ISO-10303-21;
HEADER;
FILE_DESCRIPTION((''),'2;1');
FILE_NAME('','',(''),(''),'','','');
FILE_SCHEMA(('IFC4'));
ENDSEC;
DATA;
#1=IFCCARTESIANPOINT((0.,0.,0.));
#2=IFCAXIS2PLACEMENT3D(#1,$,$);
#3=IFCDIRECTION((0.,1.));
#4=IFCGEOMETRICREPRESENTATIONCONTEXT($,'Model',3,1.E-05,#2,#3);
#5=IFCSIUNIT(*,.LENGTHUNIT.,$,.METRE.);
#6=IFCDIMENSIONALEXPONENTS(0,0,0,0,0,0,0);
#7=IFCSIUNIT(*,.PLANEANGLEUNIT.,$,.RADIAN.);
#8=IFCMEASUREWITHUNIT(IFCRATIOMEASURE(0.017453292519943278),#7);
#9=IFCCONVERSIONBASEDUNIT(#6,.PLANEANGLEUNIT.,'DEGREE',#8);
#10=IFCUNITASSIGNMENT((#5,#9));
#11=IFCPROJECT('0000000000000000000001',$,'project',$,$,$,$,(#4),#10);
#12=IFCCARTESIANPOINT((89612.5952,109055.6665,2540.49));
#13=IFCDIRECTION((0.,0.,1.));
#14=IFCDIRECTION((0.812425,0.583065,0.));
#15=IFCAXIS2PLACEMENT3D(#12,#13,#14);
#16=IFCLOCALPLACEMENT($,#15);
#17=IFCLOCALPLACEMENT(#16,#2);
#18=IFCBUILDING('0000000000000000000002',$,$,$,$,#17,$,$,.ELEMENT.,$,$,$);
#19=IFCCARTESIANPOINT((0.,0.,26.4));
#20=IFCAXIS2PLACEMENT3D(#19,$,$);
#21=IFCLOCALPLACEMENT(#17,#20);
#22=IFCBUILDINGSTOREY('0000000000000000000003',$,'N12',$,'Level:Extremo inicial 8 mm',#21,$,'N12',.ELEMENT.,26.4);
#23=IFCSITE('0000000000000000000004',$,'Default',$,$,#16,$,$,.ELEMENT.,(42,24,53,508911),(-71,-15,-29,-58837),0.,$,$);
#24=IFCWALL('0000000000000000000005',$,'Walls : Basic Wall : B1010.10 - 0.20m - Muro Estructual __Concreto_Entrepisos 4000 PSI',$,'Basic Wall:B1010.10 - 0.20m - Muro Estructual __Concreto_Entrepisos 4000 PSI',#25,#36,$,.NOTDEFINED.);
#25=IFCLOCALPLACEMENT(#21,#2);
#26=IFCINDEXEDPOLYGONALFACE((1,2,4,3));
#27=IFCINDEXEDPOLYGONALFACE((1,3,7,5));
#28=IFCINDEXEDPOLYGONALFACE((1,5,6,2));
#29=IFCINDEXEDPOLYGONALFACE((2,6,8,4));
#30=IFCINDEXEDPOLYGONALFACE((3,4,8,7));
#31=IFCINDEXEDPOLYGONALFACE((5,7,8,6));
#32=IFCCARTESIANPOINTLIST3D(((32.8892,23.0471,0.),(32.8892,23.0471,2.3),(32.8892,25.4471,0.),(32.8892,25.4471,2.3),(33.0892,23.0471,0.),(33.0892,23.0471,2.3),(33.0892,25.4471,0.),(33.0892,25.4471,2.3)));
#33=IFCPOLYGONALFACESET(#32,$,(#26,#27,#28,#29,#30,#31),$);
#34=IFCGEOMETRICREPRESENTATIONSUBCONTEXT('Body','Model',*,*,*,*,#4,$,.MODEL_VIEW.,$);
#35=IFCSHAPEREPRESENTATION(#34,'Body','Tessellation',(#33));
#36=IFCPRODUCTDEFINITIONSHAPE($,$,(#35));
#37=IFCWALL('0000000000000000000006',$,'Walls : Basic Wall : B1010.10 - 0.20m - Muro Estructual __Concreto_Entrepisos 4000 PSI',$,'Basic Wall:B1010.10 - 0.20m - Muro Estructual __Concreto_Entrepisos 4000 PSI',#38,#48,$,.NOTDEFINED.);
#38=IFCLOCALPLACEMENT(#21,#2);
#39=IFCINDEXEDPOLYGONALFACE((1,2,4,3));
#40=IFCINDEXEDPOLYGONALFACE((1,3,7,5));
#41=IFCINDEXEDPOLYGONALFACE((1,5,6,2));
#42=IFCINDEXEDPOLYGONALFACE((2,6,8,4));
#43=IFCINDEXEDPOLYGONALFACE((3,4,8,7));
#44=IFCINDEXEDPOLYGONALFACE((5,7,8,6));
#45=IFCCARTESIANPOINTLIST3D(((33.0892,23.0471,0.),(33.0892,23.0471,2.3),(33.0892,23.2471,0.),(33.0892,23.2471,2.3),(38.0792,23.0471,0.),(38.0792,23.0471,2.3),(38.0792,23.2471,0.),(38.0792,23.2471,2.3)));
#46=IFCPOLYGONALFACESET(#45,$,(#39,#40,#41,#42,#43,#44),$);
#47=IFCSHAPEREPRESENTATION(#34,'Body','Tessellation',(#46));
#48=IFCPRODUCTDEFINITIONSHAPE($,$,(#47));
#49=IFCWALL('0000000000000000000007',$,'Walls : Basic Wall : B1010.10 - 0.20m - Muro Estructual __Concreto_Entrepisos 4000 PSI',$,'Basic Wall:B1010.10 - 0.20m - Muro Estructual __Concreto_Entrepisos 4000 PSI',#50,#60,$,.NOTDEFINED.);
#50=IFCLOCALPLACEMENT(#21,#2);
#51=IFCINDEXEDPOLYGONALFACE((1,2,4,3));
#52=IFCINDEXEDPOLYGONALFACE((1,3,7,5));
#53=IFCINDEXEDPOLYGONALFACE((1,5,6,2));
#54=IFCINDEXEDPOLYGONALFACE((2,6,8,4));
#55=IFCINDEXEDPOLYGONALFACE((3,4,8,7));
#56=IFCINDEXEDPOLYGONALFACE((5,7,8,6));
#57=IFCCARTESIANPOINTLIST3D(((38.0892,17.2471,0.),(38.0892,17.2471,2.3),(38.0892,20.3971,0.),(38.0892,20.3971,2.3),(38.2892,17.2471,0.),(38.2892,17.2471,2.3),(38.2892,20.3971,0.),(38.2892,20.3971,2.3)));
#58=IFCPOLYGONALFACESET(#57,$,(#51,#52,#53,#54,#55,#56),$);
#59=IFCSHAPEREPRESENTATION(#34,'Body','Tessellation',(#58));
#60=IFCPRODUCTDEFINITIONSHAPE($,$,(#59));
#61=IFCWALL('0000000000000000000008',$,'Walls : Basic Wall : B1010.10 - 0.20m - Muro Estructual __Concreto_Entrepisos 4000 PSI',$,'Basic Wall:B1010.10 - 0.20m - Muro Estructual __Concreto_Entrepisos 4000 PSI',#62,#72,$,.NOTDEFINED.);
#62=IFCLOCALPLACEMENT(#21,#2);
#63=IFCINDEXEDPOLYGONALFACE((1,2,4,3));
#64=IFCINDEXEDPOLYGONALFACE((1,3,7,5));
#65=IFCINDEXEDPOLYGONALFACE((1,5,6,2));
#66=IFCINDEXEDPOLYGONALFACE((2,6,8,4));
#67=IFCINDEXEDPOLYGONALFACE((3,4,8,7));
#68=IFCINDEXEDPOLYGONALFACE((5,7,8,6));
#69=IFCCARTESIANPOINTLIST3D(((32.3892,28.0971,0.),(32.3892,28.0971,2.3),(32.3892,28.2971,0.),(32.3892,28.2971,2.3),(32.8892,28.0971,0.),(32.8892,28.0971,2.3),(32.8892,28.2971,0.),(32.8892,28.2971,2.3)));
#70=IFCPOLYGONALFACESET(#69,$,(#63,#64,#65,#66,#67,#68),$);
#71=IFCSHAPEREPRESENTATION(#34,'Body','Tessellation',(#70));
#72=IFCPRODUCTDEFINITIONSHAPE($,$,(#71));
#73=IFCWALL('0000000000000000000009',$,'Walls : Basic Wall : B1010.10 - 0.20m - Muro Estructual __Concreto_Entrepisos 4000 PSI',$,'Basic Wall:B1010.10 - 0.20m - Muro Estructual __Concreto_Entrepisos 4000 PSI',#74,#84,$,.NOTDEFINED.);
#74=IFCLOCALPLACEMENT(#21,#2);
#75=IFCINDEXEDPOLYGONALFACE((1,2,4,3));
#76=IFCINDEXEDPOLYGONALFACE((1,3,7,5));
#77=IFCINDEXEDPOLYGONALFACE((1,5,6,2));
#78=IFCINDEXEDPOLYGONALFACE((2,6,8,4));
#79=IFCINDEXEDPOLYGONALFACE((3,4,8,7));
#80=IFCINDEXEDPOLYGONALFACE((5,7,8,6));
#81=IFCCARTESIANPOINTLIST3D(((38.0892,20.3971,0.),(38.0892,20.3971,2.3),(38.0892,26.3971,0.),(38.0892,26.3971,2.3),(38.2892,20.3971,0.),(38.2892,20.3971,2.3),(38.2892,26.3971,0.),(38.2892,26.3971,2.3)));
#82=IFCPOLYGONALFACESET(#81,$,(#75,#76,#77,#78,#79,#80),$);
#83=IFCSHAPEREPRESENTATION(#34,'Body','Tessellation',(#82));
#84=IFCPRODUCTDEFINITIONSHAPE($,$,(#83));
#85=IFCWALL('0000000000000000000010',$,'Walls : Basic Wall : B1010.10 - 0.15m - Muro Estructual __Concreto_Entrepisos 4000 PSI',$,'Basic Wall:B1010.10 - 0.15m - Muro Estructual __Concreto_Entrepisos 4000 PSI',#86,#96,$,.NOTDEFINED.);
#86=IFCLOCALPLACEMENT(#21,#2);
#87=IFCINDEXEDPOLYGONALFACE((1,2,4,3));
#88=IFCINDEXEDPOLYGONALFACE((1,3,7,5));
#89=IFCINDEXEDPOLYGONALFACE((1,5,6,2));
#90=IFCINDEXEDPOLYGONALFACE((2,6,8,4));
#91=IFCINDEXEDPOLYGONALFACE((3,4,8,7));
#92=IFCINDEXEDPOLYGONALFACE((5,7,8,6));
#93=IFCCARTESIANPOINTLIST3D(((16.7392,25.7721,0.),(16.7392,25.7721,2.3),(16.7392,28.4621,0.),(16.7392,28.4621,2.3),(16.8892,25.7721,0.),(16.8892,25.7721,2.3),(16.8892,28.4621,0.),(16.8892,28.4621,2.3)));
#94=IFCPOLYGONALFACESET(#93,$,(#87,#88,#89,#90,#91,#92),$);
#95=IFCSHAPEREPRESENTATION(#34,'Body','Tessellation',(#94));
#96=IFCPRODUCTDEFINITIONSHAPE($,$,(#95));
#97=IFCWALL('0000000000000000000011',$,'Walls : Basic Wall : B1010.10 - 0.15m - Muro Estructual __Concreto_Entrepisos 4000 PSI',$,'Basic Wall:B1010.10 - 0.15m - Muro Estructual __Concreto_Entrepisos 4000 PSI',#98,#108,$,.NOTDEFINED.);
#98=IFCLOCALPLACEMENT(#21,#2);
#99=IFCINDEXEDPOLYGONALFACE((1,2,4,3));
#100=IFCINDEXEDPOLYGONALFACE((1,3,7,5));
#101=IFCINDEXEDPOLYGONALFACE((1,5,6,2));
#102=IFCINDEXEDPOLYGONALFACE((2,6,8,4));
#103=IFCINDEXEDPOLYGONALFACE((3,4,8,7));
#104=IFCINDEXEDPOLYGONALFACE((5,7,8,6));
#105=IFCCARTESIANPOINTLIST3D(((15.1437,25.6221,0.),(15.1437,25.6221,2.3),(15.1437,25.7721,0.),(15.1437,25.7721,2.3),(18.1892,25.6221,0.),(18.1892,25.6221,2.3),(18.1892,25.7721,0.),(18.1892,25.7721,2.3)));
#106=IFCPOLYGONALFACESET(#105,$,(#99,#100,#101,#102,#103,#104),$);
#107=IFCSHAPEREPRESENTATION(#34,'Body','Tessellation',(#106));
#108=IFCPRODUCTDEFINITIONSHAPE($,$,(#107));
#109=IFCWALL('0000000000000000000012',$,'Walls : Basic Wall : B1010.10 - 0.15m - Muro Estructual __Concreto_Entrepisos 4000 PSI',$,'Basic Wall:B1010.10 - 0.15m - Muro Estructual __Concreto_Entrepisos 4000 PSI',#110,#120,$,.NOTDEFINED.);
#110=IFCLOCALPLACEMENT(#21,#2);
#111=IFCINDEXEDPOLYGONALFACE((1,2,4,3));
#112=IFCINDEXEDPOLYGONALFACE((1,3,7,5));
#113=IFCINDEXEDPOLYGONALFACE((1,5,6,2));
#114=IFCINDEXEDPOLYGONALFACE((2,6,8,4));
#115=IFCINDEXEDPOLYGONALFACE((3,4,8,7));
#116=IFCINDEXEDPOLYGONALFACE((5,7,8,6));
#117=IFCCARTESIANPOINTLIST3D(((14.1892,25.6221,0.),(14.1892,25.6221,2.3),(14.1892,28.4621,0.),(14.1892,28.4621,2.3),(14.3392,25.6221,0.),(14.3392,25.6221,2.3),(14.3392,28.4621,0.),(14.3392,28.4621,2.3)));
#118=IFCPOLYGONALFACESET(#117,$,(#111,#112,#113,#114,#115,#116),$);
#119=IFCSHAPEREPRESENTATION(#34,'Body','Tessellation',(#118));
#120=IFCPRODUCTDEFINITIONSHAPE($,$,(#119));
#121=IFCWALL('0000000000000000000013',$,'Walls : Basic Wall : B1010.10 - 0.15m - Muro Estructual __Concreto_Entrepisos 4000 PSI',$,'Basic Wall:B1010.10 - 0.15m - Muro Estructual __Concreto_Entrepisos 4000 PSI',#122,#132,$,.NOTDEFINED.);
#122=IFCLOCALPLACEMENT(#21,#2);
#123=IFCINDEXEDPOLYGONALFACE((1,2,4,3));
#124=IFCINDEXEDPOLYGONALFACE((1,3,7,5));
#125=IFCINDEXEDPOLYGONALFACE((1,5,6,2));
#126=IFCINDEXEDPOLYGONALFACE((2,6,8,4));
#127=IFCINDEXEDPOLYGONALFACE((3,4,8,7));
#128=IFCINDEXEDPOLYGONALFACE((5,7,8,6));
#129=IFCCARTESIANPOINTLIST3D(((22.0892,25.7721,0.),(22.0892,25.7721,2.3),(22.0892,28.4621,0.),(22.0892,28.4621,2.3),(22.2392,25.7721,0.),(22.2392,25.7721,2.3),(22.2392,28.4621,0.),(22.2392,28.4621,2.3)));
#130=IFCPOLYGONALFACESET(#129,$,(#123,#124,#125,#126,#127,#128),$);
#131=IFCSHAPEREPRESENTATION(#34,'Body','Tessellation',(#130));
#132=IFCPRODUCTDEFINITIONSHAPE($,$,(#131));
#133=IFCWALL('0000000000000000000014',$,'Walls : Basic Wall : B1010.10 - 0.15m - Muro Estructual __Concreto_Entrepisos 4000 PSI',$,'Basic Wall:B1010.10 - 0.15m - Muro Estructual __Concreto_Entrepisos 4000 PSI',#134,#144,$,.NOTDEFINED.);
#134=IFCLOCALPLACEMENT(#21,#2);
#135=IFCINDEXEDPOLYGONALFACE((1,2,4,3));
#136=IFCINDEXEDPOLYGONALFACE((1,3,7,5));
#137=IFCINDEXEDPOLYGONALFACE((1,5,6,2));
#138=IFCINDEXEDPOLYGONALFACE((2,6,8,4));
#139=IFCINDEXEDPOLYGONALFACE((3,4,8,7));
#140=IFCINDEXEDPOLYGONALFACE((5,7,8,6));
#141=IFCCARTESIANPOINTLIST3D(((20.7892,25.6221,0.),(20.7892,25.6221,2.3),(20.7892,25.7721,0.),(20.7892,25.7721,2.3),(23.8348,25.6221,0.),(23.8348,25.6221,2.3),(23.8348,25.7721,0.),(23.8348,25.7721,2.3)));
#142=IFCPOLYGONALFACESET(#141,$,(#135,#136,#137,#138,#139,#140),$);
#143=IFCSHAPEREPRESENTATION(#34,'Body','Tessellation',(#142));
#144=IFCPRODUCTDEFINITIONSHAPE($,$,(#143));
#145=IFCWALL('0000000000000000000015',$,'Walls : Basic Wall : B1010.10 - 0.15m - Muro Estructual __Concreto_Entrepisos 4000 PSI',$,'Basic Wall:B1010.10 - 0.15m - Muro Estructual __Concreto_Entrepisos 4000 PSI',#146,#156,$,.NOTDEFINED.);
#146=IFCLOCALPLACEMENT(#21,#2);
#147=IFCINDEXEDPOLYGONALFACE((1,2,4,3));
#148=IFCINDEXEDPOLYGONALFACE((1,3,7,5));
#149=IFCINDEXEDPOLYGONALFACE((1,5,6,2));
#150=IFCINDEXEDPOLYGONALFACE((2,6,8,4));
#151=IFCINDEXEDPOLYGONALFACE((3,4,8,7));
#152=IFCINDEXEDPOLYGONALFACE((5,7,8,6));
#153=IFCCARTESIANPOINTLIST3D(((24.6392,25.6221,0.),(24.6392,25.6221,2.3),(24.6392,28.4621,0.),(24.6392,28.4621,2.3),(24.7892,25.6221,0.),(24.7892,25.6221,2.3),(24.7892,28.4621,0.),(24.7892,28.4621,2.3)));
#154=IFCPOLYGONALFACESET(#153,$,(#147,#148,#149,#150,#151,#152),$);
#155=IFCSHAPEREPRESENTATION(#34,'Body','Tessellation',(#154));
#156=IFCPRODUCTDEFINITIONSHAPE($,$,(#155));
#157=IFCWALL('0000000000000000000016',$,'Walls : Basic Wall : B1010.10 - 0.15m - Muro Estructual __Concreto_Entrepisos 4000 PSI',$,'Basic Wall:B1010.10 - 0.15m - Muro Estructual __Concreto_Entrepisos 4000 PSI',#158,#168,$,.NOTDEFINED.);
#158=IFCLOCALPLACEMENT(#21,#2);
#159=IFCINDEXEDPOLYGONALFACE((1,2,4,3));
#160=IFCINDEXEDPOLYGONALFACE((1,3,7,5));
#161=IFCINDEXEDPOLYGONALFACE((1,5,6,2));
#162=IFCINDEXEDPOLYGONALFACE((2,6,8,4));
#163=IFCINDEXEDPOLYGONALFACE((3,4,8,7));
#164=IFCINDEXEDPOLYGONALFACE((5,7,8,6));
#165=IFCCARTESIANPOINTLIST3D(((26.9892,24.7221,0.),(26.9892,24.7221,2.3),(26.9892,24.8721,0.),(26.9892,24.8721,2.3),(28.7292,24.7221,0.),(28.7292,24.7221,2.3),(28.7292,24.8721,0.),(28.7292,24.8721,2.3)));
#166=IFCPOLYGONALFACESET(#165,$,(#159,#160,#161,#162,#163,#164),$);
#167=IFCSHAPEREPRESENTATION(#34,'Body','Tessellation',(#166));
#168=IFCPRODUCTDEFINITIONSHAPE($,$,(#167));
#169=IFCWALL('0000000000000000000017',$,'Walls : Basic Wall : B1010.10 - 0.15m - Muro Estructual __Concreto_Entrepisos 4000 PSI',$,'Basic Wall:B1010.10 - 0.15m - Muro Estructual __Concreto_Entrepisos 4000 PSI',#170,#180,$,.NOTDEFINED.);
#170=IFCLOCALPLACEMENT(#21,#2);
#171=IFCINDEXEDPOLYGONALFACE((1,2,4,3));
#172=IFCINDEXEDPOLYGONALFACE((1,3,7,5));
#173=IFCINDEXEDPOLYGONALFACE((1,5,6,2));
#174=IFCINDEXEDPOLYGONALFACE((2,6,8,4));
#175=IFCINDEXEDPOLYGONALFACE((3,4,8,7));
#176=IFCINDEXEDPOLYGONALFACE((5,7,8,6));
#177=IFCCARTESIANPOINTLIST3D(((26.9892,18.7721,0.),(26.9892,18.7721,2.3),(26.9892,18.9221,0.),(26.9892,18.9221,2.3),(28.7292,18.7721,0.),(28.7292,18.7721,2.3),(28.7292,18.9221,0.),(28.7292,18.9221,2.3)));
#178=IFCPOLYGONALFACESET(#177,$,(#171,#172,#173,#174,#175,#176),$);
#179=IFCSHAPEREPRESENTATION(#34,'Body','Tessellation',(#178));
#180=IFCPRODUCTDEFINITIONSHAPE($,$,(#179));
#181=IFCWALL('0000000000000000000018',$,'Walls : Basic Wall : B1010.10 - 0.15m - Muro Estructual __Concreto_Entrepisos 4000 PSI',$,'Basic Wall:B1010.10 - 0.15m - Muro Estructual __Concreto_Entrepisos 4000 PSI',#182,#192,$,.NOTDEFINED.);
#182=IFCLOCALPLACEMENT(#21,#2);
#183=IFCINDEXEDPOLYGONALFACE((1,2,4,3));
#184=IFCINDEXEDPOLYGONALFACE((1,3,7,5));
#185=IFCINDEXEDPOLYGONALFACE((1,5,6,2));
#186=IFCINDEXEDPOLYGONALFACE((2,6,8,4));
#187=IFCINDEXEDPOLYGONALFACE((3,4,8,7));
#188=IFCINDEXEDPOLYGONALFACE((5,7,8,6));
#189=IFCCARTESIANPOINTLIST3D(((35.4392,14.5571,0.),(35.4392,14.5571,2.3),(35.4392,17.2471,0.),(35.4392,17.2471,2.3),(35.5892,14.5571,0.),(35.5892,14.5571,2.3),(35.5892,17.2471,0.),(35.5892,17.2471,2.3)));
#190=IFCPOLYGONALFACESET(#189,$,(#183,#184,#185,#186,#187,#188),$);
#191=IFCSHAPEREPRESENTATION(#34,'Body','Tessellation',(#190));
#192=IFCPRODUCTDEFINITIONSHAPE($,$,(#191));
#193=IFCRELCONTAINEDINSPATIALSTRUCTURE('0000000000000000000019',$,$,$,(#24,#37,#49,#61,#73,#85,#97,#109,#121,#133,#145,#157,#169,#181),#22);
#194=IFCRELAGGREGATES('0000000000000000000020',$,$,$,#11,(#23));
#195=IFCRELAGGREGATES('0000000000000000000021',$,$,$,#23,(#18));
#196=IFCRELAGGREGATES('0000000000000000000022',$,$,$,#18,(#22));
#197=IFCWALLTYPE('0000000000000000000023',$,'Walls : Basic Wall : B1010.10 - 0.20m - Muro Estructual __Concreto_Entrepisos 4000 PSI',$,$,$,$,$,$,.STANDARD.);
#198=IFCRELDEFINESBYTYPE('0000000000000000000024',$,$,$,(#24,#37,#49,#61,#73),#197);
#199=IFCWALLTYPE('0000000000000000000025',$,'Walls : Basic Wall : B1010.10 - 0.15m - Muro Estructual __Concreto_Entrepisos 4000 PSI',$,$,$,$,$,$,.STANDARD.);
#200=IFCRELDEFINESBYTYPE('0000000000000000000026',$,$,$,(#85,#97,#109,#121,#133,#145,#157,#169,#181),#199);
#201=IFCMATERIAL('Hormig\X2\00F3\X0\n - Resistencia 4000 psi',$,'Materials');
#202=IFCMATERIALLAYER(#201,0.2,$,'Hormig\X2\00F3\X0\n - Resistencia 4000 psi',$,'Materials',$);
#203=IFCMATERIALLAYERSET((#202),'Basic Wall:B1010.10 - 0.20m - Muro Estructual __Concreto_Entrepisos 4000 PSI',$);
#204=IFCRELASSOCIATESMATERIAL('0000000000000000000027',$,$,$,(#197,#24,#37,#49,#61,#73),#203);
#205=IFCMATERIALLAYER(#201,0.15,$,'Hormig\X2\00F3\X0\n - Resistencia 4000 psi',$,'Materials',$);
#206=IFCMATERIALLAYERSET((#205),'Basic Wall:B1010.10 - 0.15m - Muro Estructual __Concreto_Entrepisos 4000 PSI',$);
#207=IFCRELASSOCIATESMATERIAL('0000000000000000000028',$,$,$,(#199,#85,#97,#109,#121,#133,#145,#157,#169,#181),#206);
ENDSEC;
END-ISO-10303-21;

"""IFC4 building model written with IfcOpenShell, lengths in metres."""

from ifc_helpers import new_model, entity, si_unit, converted_unit, direction, frame, frame_2d, origin, place, context, subcontext, project, spatial, rectangle, extrude, material, layer, layer_set, layer_usage, type_object, element, save


model = new_model("IFC4")

# Units and contexts
model_context = context("Model", 3, precision=1e-05, world=origin(), true_north=direction((0.0, 1.0)))
body_context = subcontext(model_context, "Body", "Model", "MODEL_VIEW")
ifc_project = project(units=[si_unit("LENGTHUNIT", "METRE"), converted_unit("PLANEANGLEUNIT", "DEGREE", entity("IfcRatioMeasure", 0.017453292519943278), si_unit("PLANEANGLEUNIT", "RADIAN"), dimensions=[0, 0, 0, 0, 0, 0, 0])], contexts=[model_context])

# Site, building, storey
site_placement = place(None, frame((89612.5952, 109055.6665, 2540.49), z_axis=(0.0, 0.0, 1.0), x_axis=(0.812425, 0.583065, 0.0)))
site = spatial("IfcSite", under=ifc_project, at=site_placement, Name="Default", CompositionType="ELEMENT", RefLatitude=(42, 24, 53, 508911), RefLongitude=(-71, -15, -29, -58837), RefElevation=0.0)
building_placement = place(site_placement, origin())
building = spatial("IfcBuilding", under=site, at=building_placement, CompositionType="ELEMENT")
storey_placement = place(building_placement, frame((0.0, 0.0, 26.4)))
storey = spatial("IfcBuildingStorey", under=building, at=storey_placement, Name="N12", ObjectType="Level:Extremo inicial 8 mm", LongName="N12", CompositionType="ELEMENT", Elevation=26.4)

# Walls
ifc_material = material(Name="Hormigón - Resistencia 4000 psi", Category="Materials")
ifc_layer_1 = layer(ifc_material, 0.2, Name="Hormigón - Resistencia 4000 psi", Category="Materials")
ifc_layer_set_1 = layer_set([ifc_layer_1], Name="Basic Wall:B1010.10 - 0.20m - Muro Estructual __Concreto_Entrepisos 4000 PSI")
wall_type_1 = type_object("IfcWallType", Name="Walls : Basic Wall : B1010.10 - 0.20m - Muro Estructual __Concreto_Entrepisos 4000 PSI", PredefinedType="STANDARD", material=ifc_layer_set_1)
ifc_layer_usage_1 = layer_usage(ifc_layer_set_1, "AXIS2", "POSITIVE", -0.1)
wall_1_placement = place(storey_placement, frame((32.9892, 25.4471, 0.0), z_axis=(0.0, 0.0, 1.0), x_axis=(0.0, -1.0, 0.0)))
element("IfcWall", 1, at=wall_1_placement, inside=storey, type_object=wall_type_1, material=ifc_layer_usage_1, Name="Walls : Basic Wall : B1010.10 - 0.20m - Muro Estructual __Concreto_Entrepisos 4000 PSI", ObjectType="Basic Wall:B1010.10 - 0.20m - Muro Estructual __Concreto_Entrepisos 4000 PSI", PredefinedType="NOTDEFINED", context=body_context, shape_type="SweptSolid", body=[
    extrude(rectangle(XDim=2.4, YDim=0.2, at=frame_2d((1.2, 0.0), x_axis=(-1.0, 0.0))), origin(), (0.0, 0.0, 1.0), 2.3),
])
ifc_layer_usage_2 = layer_usage(ifc_layer_set_1, "AXIS2", "POSITIVE", -0.1)
wall_2_placement = place(storey_placement, frame((33.0892, 23.1471, 0.0)))
element("IfcWall", 2, at=wall_2_placement, inside=storey, type_object=wall_type_1, material=ifc_layer_usage_2, Name="Walls : Basic Wall : B1010.10 - 0.20m - Muro Estructual __Concreto_Entrepisos 4000 PSI", ObjectType="Basic Wall:B1010.10 - 0.20m - Muro Estructual __Concreto_Entrepisos 4000 PSI", PredefinedType="NOTDEFINED", context=body_context, shape_type="SweptSolid", body=[
    extrude(rectangle(XDim=4.99, YDim=0.2, at=frame_2d((2.495, 0.0), x_axis=(-1.0, 0.0))), origin(), (0.0, 0.0, 1.0), 2.3),
])
ifc_layer_usage_3 = layer_usage(ifc_layer_set_1, "AXIS2", "POSITIVE", -0.1)
wall_3_placement = place(storey_placement, frame((38.1892, 17.2471, 0.0), z_axis=(0.0, 0.0, 1.0), x_axis=(0.0, 1.0, 0.0)))
element("IfcWall", 3, at=wall_3_placement, inside=storey, type_object=wall_type_1, material=ifc_layer_usage_3, Name="Walls : Basic Wall : B1010.10 - 0.20m - Muro Estructual __Concreto_Entrepisos 4000 PSI", ObjectType="Basic Wall:B1010.10 - 0.20m - Muro Estructual __Concreto_Entrepisos 4000 PSI", PredefinedType="NOTDEFINED", context=body_context, shape_type="SweptSolid", body=[
    extrude(rectangle(XDim=3.15, YDim=0.2, at=frame_2d((1.575, 0.0), x_axis=(-1.0, 0.0))), origin(), (0.0, 0.0, 1.0), 2.3),
])
ifc_layer_usage_4 = layer_usage(ifc_layer_set_1, "AXIS2", "POSITIVE", -0.1)
wall_4_placement = place(storey_placement, frame((32.3892, 28.1971, 0.0)))
element("IfcWall", 4, at=wall_4_placement, inside=storey, type_object=wall_type_1, material=ifc_layer_usage_4, Name="Walls : Basic Wall : B1010.10 - 0.20m - Muro Estructual __Concreto_Entrepisos 4000 PSI", ObjectType="Basic Wall:B1010.10 - 0.20m - Muro Estructual __Concreto_Entrepisos 4000 PSI", PredefinedType="NOTDEFINED", context=body_context, shape_type="SweptSolid", body=[
    extrude(rectangle(XDim=0.5, YDim=0.2, at=frame_2d((0.25, 0.0), x_axis=(-1.0, 0.0))), origin(), (0.0, 0.0, 1.0), 2.3),
])
ifc_layer_usage_5 = layer_usage(ifc_layer_set_1, "AXIS2", "POSITIVE", -0.1)
wall_5_placement = place(storey_placement, frame((38.1892, 20.3971, 0.0), z_axis=(0.0, 0.0, 1.0), x_axis=(0.0, 1.0, 0.0)))
element("IfcWall", 5, at=wall_5_placement, inside=storey, type_object=wall_type_1, material=ifc_layer_usage_5, Name="Walls : Basic Wall : B1010.10 - 0.20m - Muro Estructual __Concreto_Entrepisos 4000 PSI", ObjectType="Basic Wall:B1010.10 - 0.20m - Muro Estructual __Concreto_Entrepisos 4000 PSI", PredefinedType="NOTDEFINED", context=body_context, shape_type="SweptSolid", body=[
    extrude(rectangle(XDim=6.0, YDim=0.2, at=frame_2d((3.0, 0.0), x_axis=(-1.0, 0.0))), origin(), (0.0, 0.0, 1.0), 2.3),
])
ifc_layer_2 = layer(ifc_material, 0.15, Name="Hormigón - Resistencia 4000 psi", Category="Materials")
ifc_layer_set_2 = layer_set([ifc_layer_2], Name="Basic Wall:B1010.10 - 0.15m - Muro Estructual __Concreto_Entrepisos 4000 PSI")
ifc_layer_usage_6 = layer_usage(ifc_layer_set_2, "AXIS2", "POSITIVE", -0.075)
wall_type_2 = type_object("IfcWallType", Name="Walls : Basic Wall : B1010.10 - 0.15m - Muro Estructual __Concreto_Entrepisos 4000 PSI", PredefinedType="STANDARD", material=ifc_layer_set_2)
wall_6_placement = place(storey_placement, frame((16.8142, 28.4621, 0.0), z_axis=(0.0, 0.0, 1.0), x_axis=(0.0, -1.0, 0.0)))
element("IfcWall", 6, at=wall_6_placement, inside=storey, type_object=wall_type_2, material=ifc_layer_usage_6, Name="Walls : Basic Wall : B1010.10 - 0.15m - Muro Estructual __Concreto_Entrepisos 4000 PSI", ObjectType="Basic Wall:B1010.10 - 0.15m - Muro Estructual __Concreto_Entrepisos 4000 PSI", PredefinedType="NOTDEFINED", context=body_context, shape_type="SweptSolid", body=[
    extrude(rectangle(XDim=2.69, YDim=0.15, at=frame_2d((1.345, 0.0), x_axis=(-1.0, 0.0))), origin(), (0.0, 0.0, 1.0), 2.3),
])
ifc_layer_usage_7 = layer_usage(ifc_layer_set_2, "AXIS2", "POSITIVE", -0.075)
wall_7_placement = place(storey_placement, frame((18.1892, 25.6971, 0.0), z_axis=(0.0, 0.0, 1.0), x_axis=(-1.0, 0.0, 0.0)))
element("IfcWall", 7, at=wall_7_placement, inside=storey, type_object=wall_type_2, material=ifc_layer_usage_7, Name="Walls : Basic Wall : B1010.10 - 0.15m - Muro Estructual __Concreto_Entrepisos 4000 PSI", ObjectType="Basic Wall:B1010.10 - 0.15m - Muro Estructual __Concreto_Entrepisos 4000 PSI", PredefinedType="NOTDEFINED", context=body_context, shape_type="SweptSolid", body=[
    extrude(rectangle(XDim=3.0455, YDim=0.15, at=frame_2d((1.5228, 0.0), x_axis=(-1.0, 0.0))), origin(), (0.0, 0.0, 1.0), 2.3),
])
ifc_layer_usage_8 = layer_usage(ifc_layer_set_2, "AXIS2", "POSITIVE", -0.075)
wall_8_placement = place(storey_placement, frame((14.2642, 28.4621, 0.0), z_axis=(0.0, 0.0, 1.0), x_axis=(0.0, -1.0, 0.0)))
element("IfcWall", 8, at=wall_8_placement, inside=storey, type_object=wall_type_2, material=ifc_layer_usage_8, Name="Walls : Basic Wall : B1010.10 - 0.15m - Muro Estructual __Concreto_Entrepisos 4000 PSI", ObjectType="Basic Wall:B1010.10 - 0.15m - Muro Estructual __Concreto_Entrepisos 4000 PSI", PredefinedType="NOTDEFINED", context=body_context, shape_type="SweptSolid", body=[
    extrude(rectangle(XDim=2.84, YDim=0.15, at=frame_2d((1.42, 0.0), x_axis=(-1.0, 0.0))), origin(), (0.0, 0.0, 1.0), 2.3),
])
ifc_layer_usage_9 = layer_usage(ifc_layer_set_2, "AXIS2", "NEGATIVE", 0.075)
wall_9_placement = place(storey_placement, frame((22.1642, 28.4621, 0.0), z_axis=(0.0, 0.0, 1.0), x_axis=(0.0, -1.0, 0.0)))
element("IfcWall", 9, at=wall_9_placement, inside=storey, type_object=wall_type_2, material=ifc_layer_usage_9, Name="Walls : Basic Wall : B1010.10 - 0.15m - Muro Estructual __Concreto_Entrepisos 4000 PSI", ObjectType="Basic Wall:B1010.10 - 0.15m - Muro Estructual __Concreto_Entrepisos 4000 PSI", PredefinedType="NOTDEFINED", context=body_context, shape_type="SweptSolid", body=[
    extrude(rectangle(XDim=2.69, YDim=0.15, at=frame_2d((1.345, 0.0), x_axis=(-1.0, 0.0))), origin(), (0.0, 0.0, 1.0), 2.3),
])
ifc_layer_usage_10 = layer_usage(ifc_layer_set_2, "AXIS2", "NEGATIVE", 0.075)
wall_10_placement = place(storey_placement, frame((20.7892, 25.6971, 0.0)))
element("IfcWall", 10, at=wall_10_placement, inside=storey, type_object=wall_type_2, material=ifc_layer_usage_10, Name="Walls : Basic Wall : B1010.10 - 0.15m - Muro Estructual __Concreto_Entrepisos 4000 PSI", ObjectType="Basic Wall:B1010.10 - 0.15m - Muro Estructual __Concreto_Entrepisos 4000 PSI", PredefinedType="NOTDEFINED", context=body_context, shape_type="SweptSolid", body=[
    extrude(rectangle(XDim=3.0455, YDim=0.15, at=frame_2d((1.5228, 0.0), x_axis=(-1.0, 0.0))), origin(), (0.0, 0.0, 1.0), 2.3),
])
ifc_layer_usage_11 = layer_usage(ifc_layer_set_2, "AXIS2", "NEGATIVE", 0.075)
wall_11_placement = place(storey_placement, frame((24.7142, 28.4621, 0.0), z_axis=(0.0, 0.0, 1.0), x_axis=(0.0, -1.0, 0.0)))
element("IfcWall", 11, at=wall_11_placement, inside=storey, type_object=wall_type_2, material=ifc_layer_usage_11, Name="Walls : Basic Wall : B1010.10 - 0.15m - Muro Estructual __Concreto_Entrepisos 4000 PSI", ObjectType="Basic Wall:B1010.10 - 0.15m - Muro Estructual __Concreto_Entrepisos 4000 PSI", PredefinedType="NOTDEFINED", context=body_context, shape_type="SweptSolid", body=[
    extrude(rectangle(XDim=2.84, YDim=0.15, at=frame_2d((1.42, 0.0), x_axis=(-1.0, 0.0))), origin(), (0.0, 0.0, 1.0), 2.3),
])
ifc_layer_usage_12 = layer_usage(ifc_layer_set_2, "AXIS2", "NEGATIVE", 0.075)
wall_12_placement = place(storey_placement, frame((26.9892, 24.7971, 0.0)))
element("IfcWall", 12, at=wall_12_placement, inside=storey, type_object=wall_type_2, material=ifc_layer_usage_12, Name="Walls : Basic Wall : B1010.10 - 0.15m - Muro Estructual __Concreto_Entrepisos 4000 PSI", ObjectType="Basic Wall:B1010.10 - 0.15m - Muro Estructual __Concreto_Entrepisos 4000 PSI", PredefinedType="NOTDEFINED", context=body_context, shape_type="SweptSolid", body=[
    extrude(rectangle(XDim=1.74, YDim=0.15, at=frame_2d((0.87, 0.0), x_axis=(-1.0, 0.0))), origin(), (0.0, 0.0, 1.0), 2.3),
])
ifc_layer_usage_13 = layer_usage(ifc_layer_set_2, "AXIS2", "POSITIVE", -0.075)
wall_13_placement = place(storey_placement, frame((26.9892, 18.8471, 0.0)))
element("IfcWall", 13, at=wall_13_placement, inside=storey, type_object=wall_type_2, material=ifc_layer_usage_13, Name="Walls : Basic Wall : B1010.10 - 0.15m - Muro Estructual __Concreto_Entrepisos 4000 PSI", ObjectType="Basic Wall:B1010.10 - 0.15m - Muro Estructual __Concreto_Entrepisos 4000 PSI", PredefinedType="NOTDEFINED", context=body_context, shape_type="SweptSolid", body=[
    extrude(rectangle(XDim=1.74, YDim=0.15, at=frame_2d((0.87, 0.0), x_axis=(-1.0, 0.0))), origin(), (0.0, 0.0, 1.0), 2.3),
])
ifc_layer_usage_14 = layer_usage(ifc_layer_set_2, "AXIS2", "NEGATIVE", 0.075)
wall_14_placement = place(storey_placement, frame((35.5142, 14.5571, 0.0), z_axis=(0.0, 0.0, 1.0), x_axis=(0.0, 1.0, 0.0)))
element("IfcWall", 14, at=wall_14_placement, inside=storey, type_object=wall_type_2, material=ifc_layer_usage_14, Name="Walls : Basic Wall : B1010.10 - 0.15m - Muro Estructual __Concreto_Entrepisos 4000 PSI", ObjectType="Basic Wall:B1010.10 - 0.15m - Muro Estructual __Concreto_Entrepisos 4000 PSI", PredefinedType="NOTDEFINED", context=body_context, shape_type="SweptSolid", body=[
    extrude(rectangle(XDim=2.69, YDim=0.15, at=frame_2d((1.345, 0.0), x_axis=(-1.0, 0.0))), origin(), (0.0, 0.0, 1.0), 2.3),
])

save(model, "model.ifc")
